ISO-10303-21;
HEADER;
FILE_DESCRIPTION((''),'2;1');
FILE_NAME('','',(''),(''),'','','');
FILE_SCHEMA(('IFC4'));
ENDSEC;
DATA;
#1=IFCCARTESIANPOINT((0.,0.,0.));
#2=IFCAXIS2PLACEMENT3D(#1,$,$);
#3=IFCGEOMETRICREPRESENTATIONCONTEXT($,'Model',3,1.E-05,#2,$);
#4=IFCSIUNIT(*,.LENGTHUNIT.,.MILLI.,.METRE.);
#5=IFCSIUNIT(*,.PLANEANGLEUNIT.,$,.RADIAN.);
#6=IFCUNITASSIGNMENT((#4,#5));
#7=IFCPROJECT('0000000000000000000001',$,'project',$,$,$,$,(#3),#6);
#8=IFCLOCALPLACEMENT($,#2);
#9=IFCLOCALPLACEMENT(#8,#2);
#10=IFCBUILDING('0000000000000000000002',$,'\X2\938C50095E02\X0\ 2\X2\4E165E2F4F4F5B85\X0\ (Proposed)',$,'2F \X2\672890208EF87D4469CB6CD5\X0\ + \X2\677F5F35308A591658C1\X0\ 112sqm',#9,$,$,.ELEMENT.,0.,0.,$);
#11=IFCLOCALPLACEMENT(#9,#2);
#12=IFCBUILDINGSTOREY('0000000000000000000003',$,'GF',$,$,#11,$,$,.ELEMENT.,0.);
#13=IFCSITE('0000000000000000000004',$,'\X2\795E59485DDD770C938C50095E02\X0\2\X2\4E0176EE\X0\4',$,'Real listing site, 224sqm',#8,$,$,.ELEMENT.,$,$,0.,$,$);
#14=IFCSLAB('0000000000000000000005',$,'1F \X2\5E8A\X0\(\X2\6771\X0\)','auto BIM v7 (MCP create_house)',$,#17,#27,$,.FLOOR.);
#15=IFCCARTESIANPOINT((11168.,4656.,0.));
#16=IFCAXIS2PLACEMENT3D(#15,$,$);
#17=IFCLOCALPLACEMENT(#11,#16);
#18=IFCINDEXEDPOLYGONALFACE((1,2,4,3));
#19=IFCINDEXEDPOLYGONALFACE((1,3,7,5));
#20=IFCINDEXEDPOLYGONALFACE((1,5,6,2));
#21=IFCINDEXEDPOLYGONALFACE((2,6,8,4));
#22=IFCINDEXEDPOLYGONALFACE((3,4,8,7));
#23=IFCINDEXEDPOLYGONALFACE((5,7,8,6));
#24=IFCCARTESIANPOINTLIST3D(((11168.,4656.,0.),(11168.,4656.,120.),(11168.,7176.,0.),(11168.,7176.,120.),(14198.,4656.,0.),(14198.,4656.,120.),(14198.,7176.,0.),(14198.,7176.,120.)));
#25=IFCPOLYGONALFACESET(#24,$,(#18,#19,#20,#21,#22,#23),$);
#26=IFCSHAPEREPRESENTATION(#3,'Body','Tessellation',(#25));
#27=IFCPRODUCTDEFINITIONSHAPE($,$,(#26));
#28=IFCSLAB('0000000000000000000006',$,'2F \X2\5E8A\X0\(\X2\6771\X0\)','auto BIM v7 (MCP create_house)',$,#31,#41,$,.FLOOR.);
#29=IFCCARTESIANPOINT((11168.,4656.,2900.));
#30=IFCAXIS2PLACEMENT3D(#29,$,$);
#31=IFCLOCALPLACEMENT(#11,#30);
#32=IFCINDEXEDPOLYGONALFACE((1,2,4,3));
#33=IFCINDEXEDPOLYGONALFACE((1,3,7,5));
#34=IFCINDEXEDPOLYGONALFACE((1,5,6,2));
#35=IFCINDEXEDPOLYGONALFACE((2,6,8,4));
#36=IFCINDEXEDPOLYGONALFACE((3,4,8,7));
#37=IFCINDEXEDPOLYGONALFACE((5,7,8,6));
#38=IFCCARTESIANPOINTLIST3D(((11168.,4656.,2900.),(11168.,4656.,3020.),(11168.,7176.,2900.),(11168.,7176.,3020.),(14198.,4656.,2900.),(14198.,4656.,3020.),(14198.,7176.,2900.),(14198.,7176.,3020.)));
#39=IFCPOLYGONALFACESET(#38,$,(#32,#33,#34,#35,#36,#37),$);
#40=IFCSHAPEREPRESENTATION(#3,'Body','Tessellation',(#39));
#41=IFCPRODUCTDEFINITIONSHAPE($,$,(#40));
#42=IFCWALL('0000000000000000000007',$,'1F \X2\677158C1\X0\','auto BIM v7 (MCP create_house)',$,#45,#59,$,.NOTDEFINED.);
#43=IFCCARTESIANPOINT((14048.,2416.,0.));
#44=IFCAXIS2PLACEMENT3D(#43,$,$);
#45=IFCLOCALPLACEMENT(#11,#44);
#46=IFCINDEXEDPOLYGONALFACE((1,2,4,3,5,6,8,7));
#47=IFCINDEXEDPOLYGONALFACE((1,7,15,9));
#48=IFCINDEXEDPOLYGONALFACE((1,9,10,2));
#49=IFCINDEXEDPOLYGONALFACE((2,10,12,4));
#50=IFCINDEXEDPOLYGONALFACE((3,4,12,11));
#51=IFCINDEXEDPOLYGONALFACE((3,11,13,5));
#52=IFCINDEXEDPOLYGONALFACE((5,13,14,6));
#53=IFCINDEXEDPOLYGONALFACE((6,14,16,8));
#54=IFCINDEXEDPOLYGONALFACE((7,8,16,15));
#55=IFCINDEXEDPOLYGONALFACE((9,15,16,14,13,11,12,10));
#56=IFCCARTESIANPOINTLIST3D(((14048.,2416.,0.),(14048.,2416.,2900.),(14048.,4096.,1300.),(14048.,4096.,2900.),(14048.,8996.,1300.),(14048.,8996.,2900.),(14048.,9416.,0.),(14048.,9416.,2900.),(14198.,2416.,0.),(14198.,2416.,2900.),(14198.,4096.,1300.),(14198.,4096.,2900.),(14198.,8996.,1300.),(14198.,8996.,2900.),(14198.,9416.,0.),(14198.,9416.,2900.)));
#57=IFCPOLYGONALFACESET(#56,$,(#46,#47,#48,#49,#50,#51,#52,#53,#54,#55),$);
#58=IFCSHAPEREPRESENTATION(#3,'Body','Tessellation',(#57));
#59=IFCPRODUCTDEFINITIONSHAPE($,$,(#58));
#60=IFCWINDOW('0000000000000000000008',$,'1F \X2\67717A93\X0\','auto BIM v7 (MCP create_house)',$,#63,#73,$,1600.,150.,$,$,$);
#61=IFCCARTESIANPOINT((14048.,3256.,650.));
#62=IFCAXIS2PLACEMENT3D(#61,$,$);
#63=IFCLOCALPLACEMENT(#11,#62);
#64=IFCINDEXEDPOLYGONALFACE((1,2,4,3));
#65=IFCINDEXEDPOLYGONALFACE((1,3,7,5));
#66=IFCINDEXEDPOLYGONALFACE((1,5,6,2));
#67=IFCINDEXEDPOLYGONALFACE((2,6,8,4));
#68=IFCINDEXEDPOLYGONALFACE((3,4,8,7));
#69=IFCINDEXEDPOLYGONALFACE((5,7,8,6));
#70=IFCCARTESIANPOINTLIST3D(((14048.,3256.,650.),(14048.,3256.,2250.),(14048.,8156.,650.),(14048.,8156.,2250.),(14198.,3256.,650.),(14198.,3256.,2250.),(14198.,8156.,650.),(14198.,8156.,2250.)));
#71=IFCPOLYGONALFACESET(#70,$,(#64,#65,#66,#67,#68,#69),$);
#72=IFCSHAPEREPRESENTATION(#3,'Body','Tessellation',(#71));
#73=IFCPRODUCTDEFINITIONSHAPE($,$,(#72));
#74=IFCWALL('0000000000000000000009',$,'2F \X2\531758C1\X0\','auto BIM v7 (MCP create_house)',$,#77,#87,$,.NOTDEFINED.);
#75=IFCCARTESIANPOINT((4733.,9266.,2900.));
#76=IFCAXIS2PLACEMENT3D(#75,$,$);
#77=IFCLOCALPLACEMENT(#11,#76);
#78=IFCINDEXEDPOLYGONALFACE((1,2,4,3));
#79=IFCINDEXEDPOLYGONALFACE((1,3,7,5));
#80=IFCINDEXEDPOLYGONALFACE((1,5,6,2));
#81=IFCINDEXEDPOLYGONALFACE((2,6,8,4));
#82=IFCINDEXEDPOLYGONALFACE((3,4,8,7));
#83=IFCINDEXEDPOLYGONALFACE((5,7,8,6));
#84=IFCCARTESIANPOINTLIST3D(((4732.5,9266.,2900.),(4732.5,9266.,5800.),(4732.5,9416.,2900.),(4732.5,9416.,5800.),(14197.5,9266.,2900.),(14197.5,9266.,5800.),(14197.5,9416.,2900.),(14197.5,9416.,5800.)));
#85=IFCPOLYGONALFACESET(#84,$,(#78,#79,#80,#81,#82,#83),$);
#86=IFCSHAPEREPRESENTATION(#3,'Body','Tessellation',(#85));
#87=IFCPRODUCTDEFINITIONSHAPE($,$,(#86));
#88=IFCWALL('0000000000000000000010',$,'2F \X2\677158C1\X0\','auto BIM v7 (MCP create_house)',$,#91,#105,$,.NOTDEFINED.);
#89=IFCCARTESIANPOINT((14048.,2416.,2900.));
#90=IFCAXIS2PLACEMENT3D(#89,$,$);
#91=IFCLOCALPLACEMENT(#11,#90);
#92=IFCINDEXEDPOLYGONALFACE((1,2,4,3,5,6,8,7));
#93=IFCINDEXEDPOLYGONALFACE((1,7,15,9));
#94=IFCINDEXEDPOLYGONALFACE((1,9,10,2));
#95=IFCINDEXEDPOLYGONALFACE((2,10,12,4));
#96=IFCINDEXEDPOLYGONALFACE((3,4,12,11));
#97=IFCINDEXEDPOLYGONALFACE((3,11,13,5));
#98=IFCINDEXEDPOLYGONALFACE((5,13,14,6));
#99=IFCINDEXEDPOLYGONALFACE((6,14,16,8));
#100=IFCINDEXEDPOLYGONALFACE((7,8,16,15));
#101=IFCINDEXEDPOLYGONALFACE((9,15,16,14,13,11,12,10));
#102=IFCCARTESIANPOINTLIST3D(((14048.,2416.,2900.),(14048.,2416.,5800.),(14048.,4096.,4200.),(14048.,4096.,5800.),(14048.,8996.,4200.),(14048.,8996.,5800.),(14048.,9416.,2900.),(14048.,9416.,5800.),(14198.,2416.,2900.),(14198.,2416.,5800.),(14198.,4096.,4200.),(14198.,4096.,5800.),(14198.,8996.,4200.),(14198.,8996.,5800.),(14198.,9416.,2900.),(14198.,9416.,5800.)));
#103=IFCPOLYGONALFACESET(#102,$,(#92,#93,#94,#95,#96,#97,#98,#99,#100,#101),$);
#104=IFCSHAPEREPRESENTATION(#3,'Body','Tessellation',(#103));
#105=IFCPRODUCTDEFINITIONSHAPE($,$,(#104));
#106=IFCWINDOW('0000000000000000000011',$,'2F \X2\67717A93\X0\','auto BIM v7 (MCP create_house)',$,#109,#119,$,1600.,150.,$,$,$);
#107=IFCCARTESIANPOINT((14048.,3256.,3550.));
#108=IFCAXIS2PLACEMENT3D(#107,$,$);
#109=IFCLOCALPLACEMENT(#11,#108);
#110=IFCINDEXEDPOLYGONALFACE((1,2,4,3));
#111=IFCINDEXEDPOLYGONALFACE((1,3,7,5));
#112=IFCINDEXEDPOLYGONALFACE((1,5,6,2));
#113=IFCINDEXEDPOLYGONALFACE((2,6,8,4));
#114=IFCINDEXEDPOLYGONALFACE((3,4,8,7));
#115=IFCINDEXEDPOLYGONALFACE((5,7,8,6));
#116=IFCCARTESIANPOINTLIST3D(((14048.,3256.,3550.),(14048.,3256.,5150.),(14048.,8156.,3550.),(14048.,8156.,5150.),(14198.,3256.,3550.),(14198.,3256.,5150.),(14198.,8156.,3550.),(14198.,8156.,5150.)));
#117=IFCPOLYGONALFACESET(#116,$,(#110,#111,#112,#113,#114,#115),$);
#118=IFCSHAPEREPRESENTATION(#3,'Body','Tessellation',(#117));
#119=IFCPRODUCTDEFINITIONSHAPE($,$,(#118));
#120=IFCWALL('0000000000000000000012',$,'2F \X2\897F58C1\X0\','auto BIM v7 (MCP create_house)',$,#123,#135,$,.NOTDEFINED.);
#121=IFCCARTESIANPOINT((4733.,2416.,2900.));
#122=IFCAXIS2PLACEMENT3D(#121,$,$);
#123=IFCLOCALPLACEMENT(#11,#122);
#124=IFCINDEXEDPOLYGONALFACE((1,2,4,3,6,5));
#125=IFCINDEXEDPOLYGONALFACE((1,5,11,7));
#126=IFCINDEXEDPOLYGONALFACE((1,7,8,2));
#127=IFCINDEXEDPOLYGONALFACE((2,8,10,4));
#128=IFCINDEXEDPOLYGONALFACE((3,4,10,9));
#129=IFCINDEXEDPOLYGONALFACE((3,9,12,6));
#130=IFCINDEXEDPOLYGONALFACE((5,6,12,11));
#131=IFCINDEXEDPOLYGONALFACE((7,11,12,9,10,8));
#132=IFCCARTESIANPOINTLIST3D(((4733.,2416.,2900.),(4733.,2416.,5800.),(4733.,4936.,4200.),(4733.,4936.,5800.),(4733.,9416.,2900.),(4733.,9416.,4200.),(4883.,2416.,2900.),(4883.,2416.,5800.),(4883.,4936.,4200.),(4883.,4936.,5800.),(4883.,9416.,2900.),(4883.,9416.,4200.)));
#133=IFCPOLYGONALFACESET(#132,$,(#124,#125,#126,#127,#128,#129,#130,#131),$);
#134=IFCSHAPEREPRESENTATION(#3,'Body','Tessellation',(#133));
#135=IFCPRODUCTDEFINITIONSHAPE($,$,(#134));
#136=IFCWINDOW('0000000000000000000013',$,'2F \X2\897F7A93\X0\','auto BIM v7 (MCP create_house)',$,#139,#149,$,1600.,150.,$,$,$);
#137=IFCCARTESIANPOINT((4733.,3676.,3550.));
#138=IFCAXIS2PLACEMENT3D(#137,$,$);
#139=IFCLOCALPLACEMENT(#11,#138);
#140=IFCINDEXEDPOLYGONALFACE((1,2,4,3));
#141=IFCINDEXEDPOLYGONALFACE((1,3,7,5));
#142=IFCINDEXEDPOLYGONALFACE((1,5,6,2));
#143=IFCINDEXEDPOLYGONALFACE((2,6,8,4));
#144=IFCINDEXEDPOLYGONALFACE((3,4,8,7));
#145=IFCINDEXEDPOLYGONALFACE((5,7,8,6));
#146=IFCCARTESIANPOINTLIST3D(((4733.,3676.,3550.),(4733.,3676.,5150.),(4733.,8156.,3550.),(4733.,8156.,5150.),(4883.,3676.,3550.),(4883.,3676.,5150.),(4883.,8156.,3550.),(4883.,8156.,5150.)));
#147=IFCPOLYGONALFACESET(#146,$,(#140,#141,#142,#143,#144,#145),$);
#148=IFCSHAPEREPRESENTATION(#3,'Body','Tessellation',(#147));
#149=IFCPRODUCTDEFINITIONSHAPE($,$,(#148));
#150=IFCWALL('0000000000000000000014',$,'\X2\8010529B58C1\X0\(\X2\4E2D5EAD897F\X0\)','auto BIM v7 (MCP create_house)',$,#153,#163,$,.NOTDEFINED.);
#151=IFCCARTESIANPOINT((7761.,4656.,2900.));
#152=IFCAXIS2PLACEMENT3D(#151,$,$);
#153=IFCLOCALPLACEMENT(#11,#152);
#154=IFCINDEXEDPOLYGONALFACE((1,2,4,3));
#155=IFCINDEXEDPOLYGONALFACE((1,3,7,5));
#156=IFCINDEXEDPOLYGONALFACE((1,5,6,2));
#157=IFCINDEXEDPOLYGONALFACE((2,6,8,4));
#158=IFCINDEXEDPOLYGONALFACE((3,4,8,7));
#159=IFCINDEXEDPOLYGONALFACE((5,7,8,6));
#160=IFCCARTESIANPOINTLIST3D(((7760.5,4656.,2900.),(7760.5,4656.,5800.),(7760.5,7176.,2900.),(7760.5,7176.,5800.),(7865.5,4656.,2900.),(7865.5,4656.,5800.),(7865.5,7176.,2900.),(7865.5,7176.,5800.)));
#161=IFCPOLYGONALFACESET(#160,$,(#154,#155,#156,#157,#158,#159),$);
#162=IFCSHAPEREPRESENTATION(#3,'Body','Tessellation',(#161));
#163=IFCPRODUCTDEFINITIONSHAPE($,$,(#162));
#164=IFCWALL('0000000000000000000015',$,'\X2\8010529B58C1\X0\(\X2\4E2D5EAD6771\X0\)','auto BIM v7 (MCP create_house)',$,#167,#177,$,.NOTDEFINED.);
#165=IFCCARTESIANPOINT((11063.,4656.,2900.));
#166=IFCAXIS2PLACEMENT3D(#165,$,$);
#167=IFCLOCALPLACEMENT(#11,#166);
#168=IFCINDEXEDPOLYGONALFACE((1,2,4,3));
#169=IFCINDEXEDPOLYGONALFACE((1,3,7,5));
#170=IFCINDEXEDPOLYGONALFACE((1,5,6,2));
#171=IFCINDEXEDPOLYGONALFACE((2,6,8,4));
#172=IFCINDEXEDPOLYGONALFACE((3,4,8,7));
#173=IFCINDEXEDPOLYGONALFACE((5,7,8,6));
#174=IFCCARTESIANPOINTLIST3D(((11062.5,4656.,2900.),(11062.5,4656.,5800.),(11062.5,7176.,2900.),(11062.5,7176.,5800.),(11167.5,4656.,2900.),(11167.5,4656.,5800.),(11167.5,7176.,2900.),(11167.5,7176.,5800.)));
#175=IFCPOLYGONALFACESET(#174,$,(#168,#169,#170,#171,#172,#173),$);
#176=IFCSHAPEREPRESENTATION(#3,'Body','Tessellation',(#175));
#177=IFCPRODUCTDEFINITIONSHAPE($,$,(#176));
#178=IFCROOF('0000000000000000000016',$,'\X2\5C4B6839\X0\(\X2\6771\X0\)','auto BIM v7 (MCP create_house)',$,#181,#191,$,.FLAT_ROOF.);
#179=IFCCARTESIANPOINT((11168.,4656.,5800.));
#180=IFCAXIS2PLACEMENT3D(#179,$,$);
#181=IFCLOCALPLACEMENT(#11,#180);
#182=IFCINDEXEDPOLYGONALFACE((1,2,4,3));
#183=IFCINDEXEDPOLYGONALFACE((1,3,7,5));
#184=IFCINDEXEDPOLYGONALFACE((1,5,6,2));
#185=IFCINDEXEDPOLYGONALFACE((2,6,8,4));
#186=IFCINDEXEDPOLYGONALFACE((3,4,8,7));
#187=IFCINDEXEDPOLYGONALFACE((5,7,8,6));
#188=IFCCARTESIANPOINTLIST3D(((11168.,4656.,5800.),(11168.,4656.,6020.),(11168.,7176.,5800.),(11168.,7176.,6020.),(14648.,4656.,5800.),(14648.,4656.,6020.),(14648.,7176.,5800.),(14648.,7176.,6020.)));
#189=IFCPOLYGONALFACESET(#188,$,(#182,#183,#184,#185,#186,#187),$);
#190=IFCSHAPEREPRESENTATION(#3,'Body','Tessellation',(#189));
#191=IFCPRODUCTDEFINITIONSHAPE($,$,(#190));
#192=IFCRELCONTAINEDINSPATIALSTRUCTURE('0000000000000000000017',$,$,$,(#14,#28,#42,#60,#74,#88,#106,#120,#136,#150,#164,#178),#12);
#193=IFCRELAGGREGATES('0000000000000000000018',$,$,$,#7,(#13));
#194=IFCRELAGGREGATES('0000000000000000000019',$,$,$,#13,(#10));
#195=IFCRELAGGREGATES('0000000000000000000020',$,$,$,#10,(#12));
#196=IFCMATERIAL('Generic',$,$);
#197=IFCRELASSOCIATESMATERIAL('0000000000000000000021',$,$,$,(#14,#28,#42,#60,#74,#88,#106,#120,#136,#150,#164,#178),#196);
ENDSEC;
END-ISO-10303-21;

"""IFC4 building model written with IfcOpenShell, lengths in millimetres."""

from ifc_helpers import new_model, si_unit, frame, frame_2d, origin, place, context, project, spatial, rectangle, extrude, material, element, fill, save


model = new_model("IFC4")

# Units and contexts
model_context = context("Model", 3, precision=1e-05, world=origin())
ifc_project = project(units=[si_unit("LENGTHUNIT", "METRE", prefix="MILLI"), si_unit("PLANEANGLEUNIT", "RADIAN")], contexts=[model_context])

# Site, building, storey
site_placement = place(None, origin())
site = spatial("IfcSite", under=ifc_project, at=site_placement, Name="神奈川県鎌倉市2丁目4", ObjectType="Real listing site, 224sqm", CompositionType="ELEMENT", RefElevation=0.0)
building_placement = place(site_placement, origin())
building = spatial("IfcBuilding", under=site, at=building_placement, Name="鎌倉市 2世帯住宅 (Proposed)", ObjectType="2F 木造軸組構法 + 板張り外壁 112sqm", CompositionType="ELEMENT", ElevationOfRefHeight=0.0, ElevationOfTerrain=0.0)
storey_placement = place(building_placement, origin())
storey = spatial("IfcBuildingStorey", under=building, at=storey_placement, Name="GF", CompositionType="ELEMENT", Elevation=0.0)

# Slabs
ifc_material = material(Name="Generic")
slab_1_placement = place(storey_placement, frame((11168.0, 4656.0, 0.0)))
element("IfcSlab", 1, at=slab_1_placement, inside=storey, material=ifc_material, Name="1F 床(東)", Description="auto BIM v7 (MCP create_house)", PredefinedType="FLOOR", context=model_context, shape_type="SweptSolid", body=[
    extrude(rectangle(XDim=3030.0, YDim=2520.0, at=frame_2d((1515.0, 1260.0))), frame((11168.0, 4656.0, 0.0)), (0.0, 0.0, 1.0), 120.0),
])
slab_2_placement = place(storey_placement, frame((11168.0, 4656.0, 2900.0)))
element("IfcSlab", 2, at=slab_2_placement, inside=storey, material=ifc_material, Name="2F 床(東)", Description="auto BIM v7 (MCP create_house)", PredefinedType="FLOOR", context=model_context, shape_type="SweptSolid", body=[
    extrude(rectangle(XDim=3030.0, YDim=2520.0, at=frame_2d((1515.0, 1260.0))), frame((11168.0, 4656.0, 2900.0)), (0.0, 0.0, 1.0), 120.0),
])

# Wall, opening, window
wall_1_placement = place(storey_placement, frame((14048.0, 2416.0, 0.0)))
wall_1 = element("IfcWall", 3, at=wall_1_placement, inside=storey, material=ifc_material, Name="1F 東壁", Description="auto BIM v7 (MCP create_house)", PredefinedType="NOTDEFINED", context=model_context, shape_type="SweptSolid", body=[
    extrude(rectangle(XDim=150.0, YDim=7000.0, at=frame_2d((75.0, 3500.0))), frame((14048.0, 2416.0, 0.0)), (0.0, 0.0, 1.0), 2900.0),
])
opening_1_placement = place(storey_placement, frame((14048.0, 3256.0, 650.0)))
opening_1 = element("IfcOpeningElement", 4, at=opening_1_placement, cuts=wall_1, PredefinedType="NOTDEFINED", context=model_context, shape_type="SweptSolid", body=[
    extrude(rectangle(XDim=150.0, YDim=4900.0, at=frame_2d((75.0, 2450.0))), frame((14048.0, 3256.0, 650.0)), (0.0, 0.0, 1.0), 1600.0),
])
window_1_placement = place(storey_placement, frame((14048.0, 3256.0, 650.0)))
window_1 = element("IfcWindow", 5, at=window_1_placement, inside=storey, material=ifc_material, Name="1F 東窓", Description="auto BIM v7 (MCP create_house)", OverallHeight=1600.0, OverallWidth=150.0, context=model_context, shape_type="SweptSolid", body=[
    extrude(rectangle(XDim=150.0, YDim=4900.0, at=frame_2d((75.0, 2450.0))), frame((14048.0, 3256.0, 650.0)), (0.0, 0.0, 1.0), 1600.0),
])
fill(opening_1, window_1)

# Wall
wall_2_placement = place(storey_placement, frame((4733.0, 9266.0, 2900.0)))
element("IfcWall", 6, at=wall_2_placement, inside=storey, material=ifc_material, Name="2F 北壁", Description="auto BIM v7 (MCP create_house)", PredefinedType="NOTDEFINED", context=model_context, shape_type="SweptSolid", body=[
    extrude(rectangle(XDim=9465.0, YDim=150.0, at=frame_2d((4732.0, 75.0))), frame((4733.0, 9266.0, 2900.0)), (0.0, 0.0, 1.0), 2900.0),
])

# Walls, openings, windows
wall_3_placement = place(storey_placement, frame((14048.0, 2416.0, 2900.0)))
wall_3 = element("IfcWall", 7, at=wall_3_placement, inside=storey, material=ifc_material, Name="2F 東壁", Description="auto BIM v7 (MCP create_house)", PredefinedType="NOTDEFINED", context=model_context, shape_type="SweptSolid", body=[
    extrude(rectangle(XDim=150.0, YDim=7000.0, at=frame_2d((75.0, 3500.0))), frame((14048.0, 2416.0, 2900.0)), (0.0, 0.0, 1.0), 2900.0),
])
opening_2_placement = place(storey_placement, frame((14048.0, 3256.0, 3550.0)))
opening_2 = element("IfcOpeningElement", 8, at=opening_2_placement, cuts=wall_3, PredefinedType="NOTDEFINED", context=model_context, shape_type="SweptSolid", body=[
    extrude(rectangle(XDim=150.0, YDim=4900.0, at=frame_2d((75.0, 2450.0))), frame((14048.0, 3256.0, 3550.0)), (0.0, 0.0, 1.0), 1600.0),
])
window_2_placement = place(storey_placement, frame((14048.0, 3256.0, 3550.0)))
window_2 = element("IfcWindow", 9, at=window_2_placement, inside=storey, material=ifc_material, Name="2F 東窓", Description="auto BIM v7 (MCP create_house)", OverallHeight=1600.0, OverallWidth=150.0, context=model_context, shape_type="SweptSolid", body=[
    extrude(rectangle(XDim=150.0, YDim=4900.0, at=frame_2d((75.0, 2450.0))), frame((14048.0, 3256.0, 3550.0)), (0.0, 0.0, 1.0), 1600.0),
])
fill(opening_2, window_2)
wall_4_placement = place(storey_placement, frame((4733.0, 2416.0, 2900.0)))
wall_4 = element("IfcWall", 10, at=wall_4_placement, inside=storey, material=ifc_material, Name="2F 西壁", Description="auto BIM v7 (MCP create_house)", PredefinedType="NOTDEFINED", context=model_context, shape_type="SweptSolid", body=[
    extrude(rectangle(XDim=150.0, YDim=7000.0, at=frame_2d((75.0, 3500.0))), frame((4733.0, 2416.0, 2900.0)), (0.0, 0.0, 1.0), 2900.0),
])
opening_3_placement = place(storey_placement, frame((4733.0, 3676.0, 3550.0)))
opening_3 = element("IfcOpeningElement", 11, at=opening_3_placement, cuts=wall_4, PredefinedType="NOTDEFINED", context=model_context, shape_type="SweptSolid", body=[
    extrude(rectangle(XDim=150.0, YDim=4480.0, at=frame_2d((75.0, 2240.0))), frame((4733.0, 3676.0, 3550.0)), (0.0, 0.0, 1.0), 1600.0),
])
window_3_placement = place(storey_placement, frame((4733.0, 3676.0, 3550.0)))
window_3 = element("IfcWindow", 12, at=window_3_placement, inside=storey, material=ifc_material, Name="2F 西窓", Description="auto BIM v7 (MCP create_house)", OverallHeight=1600.0, OverallWidth=150.0, context=model_context, shape_type="SweptSolid", body=[
    extrude(rectangle(XDim=150.0, YDim=4480.0, at=frame_2d((75.0, 2240.0))), frame((4733.0, 3676.0, 3550.0)), (0.0, 0.0, 1.0), 1600.0),
])
fill(opening_3, window_3)

# Walls
wall_5_placement = place(storey_placement, frame((7761.0, 4656.0, 2900.0)))
element("IfcWall", 13, at=wall_5_placement, inside=storey, material=ifc_material, Name="耐力壁(中庭西)", Description="auto BIM v7 (MCP create_house)", PredefinedType="NOTDEFINED", context=model_context, shape_type="SweptSolid", body=[
    extrude(rectangle(XDim=105.0, YDim=2520.0, at=frame_2d((52.0, 1260.0))), frame((7761.0, 4656.0, 2900.0)), (0.0, 0.0, 1.0), 2900.0),
])
wall_6_placement = place(storey_placement, frame((11063.0, 4656.0, 2900.0)))
element("IfcWall", 14, at=wall_6_placement, inside=storey, material=ifc_material, Name="耐力壁(中庭東)", Description="auto BIM v7 (MCP create_house)", PredefinedType="NOTDEFINED", context=model_context, shape_type="SweptSolid", body=[
    extrude(rectangle(XDim=105.0, YDim=2520.0, at=frame_2d((52.0, 1260.0))), frame((11063.0, 4656.0, 2900.0)), (0.0, 0.0, 1.0), 2900.0),
])

# Roof
for number, where, name in (
    (15, (11168.0, 4656.0, 5800.0), "屋根(東)"),
):
    element("IfcRoof", number, at=place(storey_placement, frame(where)), inside=storey, material=ifc_material, Name=name, Description="auto BIM v7 (MCP create_house)", PredefinedType="FLAT_ROOF", context=model_context, shape_type="SweptSolid", body=[
        extrude(rectangle(XDim=3480.0, YDim=2520.0, at=frame_2d((1740.0, 1260.0))), frame((11168.0, 4656.0, 5800.0)), (0.0, 0.0, 1.0), 220.0),
    ])

save(model, "model.ifc")
